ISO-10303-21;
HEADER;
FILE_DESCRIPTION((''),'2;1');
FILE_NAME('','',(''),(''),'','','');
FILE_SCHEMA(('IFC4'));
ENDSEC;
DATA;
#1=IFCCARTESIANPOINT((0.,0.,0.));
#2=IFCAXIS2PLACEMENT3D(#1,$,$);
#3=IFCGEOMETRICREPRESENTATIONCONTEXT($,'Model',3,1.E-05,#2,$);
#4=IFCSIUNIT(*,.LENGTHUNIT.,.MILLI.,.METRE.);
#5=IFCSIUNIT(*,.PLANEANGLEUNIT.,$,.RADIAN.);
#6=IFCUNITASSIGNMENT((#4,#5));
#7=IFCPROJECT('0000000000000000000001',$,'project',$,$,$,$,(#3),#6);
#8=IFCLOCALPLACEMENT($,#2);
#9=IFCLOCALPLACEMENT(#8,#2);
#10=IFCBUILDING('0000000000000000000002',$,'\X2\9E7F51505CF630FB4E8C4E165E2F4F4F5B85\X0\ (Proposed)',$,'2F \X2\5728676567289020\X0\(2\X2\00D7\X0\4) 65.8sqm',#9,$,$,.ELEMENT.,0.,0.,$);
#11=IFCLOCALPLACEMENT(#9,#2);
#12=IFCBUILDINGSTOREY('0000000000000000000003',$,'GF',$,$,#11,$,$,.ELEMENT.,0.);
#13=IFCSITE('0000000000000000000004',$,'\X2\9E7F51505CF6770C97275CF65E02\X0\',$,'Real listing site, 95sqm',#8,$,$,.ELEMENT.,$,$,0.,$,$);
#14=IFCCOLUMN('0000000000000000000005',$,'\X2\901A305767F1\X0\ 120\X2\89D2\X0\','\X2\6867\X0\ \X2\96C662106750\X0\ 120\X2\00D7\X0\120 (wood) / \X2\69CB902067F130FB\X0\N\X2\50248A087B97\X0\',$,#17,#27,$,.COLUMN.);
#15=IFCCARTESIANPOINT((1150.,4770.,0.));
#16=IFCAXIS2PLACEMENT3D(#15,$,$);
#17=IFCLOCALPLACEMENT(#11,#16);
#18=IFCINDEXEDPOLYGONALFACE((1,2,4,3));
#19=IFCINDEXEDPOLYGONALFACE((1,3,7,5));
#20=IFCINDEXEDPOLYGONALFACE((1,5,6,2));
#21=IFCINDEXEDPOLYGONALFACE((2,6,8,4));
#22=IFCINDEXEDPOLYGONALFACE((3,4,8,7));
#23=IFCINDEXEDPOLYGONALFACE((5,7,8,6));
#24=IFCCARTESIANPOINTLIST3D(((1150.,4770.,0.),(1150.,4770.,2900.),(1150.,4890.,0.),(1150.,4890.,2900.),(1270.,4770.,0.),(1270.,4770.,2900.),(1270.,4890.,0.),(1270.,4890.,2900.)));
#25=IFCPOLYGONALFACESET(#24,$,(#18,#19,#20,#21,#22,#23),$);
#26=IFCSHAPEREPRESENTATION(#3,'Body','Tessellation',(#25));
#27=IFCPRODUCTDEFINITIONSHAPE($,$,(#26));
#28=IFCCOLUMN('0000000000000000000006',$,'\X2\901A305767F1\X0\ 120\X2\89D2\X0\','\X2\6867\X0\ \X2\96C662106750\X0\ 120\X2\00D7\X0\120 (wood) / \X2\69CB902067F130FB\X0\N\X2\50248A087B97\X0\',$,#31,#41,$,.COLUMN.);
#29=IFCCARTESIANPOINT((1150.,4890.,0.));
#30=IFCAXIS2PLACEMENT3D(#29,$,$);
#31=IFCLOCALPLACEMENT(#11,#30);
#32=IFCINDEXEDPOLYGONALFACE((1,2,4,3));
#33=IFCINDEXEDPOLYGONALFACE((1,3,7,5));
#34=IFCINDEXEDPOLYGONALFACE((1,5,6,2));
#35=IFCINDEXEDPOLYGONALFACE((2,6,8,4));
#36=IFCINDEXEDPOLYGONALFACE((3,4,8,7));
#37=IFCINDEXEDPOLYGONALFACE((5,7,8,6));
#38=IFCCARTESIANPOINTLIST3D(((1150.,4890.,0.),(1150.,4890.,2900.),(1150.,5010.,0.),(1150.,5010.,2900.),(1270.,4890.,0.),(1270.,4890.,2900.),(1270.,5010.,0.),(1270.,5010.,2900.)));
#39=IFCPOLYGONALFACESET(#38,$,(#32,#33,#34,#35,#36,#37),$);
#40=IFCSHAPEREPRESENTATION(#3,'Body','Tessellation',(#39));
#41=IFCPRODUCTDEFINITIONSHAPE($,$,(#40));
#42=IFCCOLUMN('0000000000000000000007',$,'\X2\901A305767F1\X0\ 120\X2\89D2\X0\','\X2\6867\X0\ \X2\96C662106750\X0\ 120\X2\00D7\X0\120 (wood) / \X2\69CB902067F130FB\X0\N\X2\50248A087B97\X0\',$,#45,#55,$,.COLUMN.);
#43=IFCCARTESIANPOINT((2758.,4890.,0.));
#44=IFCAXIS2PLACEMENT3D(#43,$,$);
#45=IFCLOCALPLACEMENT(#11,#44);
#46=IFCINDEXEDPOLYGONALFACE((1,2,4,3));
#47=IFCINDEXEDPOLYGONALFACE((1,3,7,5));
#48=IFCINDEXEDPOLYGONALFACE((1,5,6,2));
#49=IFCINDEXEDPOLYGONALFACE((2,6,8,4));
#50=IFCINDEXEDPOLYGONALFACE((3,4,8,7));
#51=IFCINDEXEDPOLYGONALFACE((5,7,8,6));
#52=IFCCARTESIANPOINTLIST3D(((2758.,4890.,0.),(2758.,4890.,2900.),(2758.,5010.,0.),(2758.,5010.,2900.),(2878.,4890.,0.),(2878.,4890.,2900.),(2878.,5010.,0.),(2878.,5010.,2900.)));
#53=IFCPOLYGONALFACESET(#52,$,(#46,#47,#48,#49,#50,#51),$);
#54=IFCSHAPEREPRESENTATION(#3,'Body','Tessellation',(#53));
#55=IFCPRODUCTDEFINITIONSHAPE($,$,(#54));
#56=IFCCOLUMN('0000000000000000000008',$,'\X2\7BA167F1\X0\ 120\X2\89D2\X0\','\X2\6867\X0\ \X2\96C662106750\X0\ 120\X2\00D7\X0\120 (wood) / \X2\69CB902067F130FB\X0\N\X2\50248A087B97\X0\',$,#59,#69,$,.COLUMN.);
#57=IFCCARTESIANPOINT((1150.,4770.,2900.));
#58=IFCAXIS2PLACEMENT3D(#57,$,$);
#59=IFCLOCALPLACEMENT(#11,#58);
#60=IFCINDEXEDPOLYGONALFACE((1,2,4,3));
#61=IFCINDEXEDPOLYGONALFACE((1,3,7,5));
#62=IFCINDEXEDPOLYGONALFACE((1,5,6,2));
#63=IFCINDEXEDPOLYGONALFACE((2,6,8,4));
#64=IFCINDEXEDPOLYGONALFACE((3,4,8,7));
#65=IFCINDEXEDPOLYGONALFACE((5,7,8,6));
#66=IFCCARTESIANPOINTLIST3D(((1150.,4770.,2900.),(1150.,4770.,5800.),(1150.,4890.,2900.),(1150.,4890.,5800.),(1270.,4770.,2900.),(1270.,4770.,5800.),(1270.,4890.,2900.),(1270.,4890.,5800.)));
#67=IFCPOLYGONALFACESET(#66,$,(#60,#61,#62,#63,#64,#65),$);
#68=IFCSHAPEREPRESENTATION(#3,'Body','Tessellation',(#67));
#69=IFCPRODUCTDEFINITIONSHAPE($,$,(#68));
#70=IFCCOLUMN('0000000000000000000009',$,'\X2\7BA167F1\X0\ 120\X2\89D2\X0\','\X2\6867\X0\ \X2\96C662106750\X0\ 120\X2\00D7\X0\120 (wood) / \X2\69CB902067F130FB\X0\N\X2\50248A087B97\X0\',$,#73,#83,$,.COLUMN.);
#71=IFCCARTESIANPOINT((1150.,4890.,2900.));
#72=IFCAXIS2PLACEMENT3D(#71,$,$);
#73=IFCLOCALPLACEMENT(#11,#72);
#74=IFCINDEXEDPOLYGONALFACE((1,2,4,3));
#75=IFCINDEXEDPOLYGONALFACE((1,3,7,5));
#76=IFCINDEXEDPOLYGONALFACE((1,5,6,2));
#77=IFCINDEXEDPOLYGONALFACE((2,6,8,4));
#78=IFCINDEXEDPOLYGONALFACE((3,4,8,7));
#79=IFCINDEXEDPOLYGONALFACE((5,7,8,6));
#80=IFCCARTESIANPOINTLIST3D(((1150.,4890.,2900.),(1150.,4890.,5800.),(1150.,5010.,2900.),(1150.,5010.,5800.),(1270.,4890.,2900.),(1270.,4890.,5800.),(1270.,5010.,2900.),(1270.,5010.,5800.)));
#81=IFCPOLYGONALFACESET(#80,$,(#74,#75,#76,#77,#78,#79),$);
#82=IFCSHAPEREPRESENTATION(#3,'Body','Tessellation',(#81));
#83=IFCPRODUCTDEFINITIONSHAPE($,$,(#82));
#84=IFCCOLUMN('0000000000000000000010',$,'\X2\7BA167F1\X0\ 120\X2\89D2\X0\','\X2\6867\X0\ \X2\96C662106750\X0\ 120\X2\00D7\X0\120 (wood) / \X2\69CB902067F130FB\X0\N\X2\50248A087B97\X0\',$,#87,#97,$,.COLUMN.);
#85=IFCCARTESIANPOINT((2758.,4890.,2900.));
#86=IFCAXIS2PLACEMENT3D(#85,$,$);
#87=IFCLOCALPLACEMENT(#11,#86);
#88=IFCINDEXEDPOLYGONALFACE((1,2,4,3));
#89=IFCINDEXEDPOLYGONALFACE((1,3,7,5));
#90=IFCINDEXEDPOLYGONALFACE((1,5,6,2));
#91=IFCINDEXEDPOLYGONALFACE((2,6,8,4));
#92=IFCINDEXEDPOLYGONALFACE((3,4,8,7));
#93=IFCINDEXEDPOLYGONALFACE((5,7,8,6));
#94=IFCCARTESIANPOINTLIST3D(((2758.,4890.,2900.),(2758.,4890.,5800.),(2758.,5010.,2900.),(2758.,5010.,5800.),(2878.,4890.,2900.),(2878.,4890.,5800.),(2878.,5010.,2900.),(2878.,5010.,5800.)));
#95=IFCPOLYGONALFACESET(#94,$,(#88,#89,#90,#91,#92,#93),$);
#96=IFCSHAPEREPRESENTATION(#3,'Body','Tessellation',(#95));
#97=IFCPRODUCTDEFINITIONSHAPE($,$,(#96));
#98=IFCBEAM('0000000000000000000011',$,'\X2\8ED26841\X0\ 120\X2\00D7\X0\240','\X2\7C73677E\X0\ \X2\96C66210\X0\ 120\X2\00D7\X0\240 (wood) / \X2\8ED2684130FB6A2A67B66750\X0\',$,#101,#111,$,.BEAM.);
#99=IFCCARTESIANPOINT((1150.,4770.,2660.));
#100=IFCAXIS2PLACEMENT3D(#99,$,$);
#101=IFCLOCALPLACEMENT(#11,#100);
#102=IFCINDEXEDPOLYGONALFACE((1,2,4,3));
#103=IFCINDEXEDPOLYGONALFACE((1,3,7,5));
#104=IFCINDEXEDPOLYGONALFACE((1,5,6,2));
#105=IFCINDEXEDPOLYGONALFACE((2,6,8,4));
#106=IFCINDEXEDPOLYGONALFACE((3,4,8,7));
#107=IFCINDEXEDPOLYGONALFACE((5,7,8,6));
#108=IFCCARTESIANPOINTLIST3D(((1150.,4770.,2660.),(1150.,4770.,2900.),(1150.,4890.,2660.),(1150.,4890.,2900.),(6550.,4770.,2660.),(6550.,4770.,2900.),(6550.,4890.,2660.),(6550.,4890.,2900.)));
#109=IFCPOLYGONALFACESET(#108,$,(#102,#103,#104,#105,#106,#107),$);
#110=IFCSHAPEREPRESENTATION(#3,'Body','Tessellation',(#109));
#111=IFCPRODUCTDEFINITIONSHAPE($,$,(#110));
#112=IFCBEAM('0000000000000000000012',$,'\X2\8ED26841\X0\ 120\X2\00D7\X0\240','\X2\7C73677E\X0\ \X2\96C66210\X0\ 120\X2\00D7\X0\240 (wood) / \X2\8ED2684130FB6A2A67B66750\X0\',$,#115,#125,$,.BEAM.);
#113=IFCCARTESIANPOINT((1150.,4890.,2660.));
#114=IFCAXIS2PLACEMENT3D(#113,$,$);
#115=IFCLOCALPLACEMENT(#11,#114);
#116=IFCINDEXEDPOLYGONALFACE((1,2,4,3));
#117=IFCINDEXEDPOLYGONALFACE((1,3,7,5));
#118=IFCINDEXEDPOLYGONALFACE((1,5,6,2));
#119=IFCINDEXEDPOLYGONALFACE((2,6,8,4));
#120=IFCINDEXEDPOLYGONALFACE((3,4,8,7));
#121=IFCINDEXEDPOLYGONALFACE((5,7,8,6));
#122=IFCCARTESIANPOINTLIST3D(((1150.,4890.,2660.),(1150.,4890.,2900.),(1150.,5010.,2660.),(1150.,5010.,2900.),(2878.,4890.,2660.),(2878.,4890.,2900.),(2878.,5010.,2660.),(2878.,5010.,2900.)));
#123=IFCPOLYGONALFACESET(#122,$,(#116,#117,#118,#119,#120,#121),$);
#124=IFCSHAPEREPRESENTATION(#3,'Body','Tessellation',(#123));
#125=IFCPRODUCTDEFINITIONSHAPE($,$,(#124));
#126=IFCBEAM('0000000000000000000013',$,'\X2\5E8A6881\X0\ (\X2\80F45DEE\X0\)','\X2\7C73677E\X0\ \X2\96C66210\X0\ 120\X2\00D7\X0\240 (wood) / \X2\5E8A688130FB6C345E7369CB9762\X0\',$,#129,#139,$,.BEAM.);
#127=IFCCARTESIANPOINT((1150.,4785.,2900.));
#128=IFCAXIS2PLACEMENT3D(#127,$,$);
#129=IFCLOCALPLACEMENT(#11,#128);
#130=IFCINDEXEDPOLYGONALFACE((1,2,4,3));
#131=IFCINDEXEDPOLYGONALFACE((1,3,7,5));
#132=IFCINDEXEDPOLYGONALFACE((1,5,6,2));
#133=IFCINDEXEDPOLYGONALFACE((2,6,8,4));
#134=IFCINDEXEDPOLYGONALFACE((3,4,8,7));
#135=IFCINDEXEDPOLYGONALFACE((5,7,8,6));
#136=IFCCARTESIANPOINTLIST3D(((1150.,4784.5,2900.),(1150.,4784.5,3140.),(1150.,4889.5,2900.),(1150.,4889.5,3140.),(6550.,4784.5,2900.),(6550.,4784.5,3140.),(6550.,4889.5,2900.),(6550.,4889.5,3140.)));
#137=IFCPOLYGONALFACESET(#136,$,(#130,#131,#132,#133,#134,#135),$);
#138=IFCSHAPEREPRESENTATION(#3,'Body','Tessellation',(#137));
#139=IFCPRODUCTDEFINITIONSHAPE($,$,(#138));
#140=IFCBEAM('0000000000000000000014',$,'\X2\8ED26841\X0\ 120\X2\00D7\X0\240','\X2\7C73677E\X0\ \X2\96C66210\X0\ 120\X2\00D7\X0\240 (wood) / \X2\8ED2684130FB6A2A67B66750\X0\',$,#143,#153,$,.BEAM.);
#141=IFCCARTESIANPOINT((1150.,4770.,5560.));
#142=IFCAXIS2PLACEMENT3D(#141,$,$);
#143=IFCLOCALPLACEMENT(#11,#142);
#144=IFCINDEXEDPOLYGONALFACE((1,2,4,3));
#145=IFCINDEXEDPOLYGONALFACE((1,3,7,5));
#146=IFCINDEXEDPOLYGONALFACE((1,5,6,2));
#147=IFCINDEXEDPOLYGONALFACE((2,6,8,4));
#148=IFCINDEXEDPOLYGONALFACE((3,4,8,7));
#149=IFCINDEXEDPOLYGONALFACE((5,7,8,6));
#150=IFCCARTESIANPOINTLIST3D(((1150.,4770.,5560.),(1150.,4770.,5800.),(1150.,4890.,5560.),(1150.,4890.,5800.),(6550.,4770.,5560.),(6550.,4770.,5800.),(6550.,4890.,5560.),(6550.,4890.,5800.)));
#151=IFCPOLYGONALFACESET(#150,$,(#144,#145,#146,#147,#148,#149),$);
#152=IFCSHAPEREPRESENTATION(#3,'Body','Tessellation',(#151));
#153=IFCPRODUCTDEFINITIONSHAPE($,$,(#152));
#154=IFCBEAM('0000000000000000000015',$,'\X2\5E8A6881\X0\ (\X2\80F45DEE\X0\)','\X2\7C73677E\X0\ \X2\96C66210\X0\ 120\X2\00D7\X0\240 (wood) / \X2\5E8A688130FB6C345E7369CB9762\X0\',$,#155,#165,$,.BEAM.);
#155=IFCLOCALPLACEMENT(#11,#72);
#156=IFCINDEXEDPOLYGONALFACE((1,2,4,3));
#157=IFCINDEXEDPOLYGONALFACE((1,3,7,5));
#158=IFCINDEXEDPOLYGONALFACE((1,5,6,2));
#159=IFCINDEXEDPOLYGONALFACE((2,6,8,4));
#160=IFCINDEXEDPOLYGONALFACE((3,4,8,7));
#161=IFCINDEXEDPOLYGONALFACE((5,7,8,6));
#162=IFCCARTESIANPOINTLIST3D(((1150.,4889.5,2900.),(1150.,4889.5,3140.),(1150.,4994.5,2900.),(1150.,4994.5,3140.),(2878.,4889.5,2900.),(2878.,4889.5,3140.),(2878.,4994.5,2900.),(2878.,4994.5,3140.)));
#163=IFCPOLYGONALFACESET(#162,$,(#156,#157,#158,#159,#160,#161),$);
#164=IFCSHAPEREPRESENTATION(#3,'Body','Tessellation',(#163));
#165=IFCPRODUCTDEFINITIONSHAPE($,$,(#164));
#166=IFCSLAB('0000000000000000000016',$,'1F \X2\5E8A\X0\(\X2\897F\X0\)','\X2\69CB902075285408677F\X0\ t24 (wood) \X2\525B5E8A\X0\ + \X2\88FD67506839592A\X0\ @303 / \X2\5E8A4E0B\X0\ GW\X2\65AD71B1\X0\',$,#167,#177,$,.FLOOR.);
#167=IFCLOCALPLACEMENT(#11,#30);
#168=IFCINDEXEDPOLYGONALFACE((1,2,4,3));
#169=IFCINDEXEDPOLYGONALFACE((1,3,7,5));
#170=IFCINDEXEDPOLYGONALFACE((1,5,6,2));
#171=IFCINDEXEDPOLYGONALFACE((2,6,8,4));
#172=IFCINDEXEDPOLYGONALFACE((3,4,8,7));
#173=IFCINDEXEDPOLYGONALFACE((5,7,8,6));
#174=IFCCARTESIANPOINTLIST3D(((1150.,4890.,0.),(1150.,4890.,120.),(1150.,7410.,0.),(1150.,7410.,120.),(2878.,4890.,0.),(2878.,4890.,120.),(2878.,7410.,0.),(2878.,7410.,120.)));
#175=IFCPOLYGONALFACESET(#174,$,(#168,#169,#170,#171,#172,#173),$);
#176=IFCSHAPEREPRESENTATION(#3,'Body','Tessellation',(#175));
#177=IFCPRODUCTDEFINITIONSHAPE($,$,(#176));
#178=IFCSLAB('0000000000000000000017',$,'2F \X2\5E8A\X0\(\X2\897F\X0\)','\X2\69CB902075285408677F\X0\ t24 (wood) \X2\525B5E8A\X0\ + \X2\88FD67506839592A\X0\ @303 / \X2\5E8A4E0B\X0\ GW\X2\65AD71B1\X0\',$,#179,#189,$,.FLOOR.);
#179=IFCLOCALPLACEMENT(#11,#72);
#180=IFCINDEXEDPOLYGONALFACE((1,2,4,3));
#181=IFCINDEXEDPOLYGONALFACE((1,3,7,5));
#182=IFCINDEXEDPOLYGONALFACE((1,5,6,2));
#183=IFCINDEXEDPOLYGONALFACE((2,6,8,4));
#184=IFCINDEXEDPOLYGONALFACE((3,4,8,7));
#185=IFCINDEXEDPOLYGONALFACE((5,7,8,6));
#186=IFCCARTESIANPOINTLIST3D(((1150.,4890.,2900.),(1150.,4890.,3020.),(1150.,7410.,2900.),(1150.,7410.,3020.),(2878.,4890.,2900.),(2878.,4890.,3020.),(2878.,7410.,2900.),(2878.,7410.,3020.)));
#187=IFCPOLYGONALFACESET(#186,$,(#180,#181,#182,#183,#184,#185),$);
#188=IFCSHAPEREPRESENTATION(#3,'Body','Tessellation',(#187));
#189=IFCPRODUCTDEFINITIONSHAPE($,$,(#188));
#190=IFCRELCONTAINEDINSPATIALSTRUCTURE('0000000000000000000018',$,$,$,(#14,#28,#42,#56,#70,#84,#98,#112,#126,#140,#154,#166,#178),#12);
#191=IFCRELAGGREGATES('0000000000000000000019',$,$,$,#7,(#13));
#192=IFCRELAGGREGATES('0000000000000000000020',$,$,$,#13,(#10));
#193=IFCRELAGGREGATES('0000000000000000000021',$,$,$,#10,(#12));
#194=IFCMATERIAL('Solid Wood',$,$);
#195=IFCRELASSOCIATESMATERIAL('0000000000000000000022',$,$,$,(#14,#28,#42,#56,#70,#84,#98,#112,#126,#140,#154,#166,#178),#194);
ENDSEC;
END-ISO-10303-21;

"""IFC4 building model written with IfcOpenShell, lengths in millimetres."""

from ifc_helpers import new_model, si_unit, frame, frame_2d, origin, place, context, project, spatial, rectangle, extrude, material, element, save


model = new_model("IFC4")

# Units and contexts
model_context = context("Model", 3, precision=1e-05, world=origin())
ifc_project = project(units=[si_unit("LENGTHUNIT", "METRE", prefix="MILLI"), si_unit("PLANEANGLEUNIT", "RADIAN")], contexts=[model_context])

# Site, building, storey
site_placement = place(None, origin())
site = spatial("IfcSite", under=ifc_project, at=site_placement, Name="鹿児島県霧島市", ObjectType="Real listing site, 95sqm", CompositionType="ELEMENT", RefElevation=0.0)
building_placement = place(site_placement, origin())
building = spatial("IfcBuilding", under=site, at=building_placement, Name="鹿児島・二世帯住宅 (Proposed)", ObjectType="2F 在来木造(2×4) 65.8sqm", CompositionType="ELEMENT", ElevationOfRefHeight=0.0, ElevationOfTerrain=0.0)
storey_placement = place(building_placement, origin())
storey = spatial("IfcBuildingStorey", under=building, at=storey_placement, Name="GF", CompositionType="ELEMENT", Elevation=0.0)

# Columns
ifc_material_1 = material(Name="Solid Wood")
column_1_placement = place(storey_placement, frame((1150.0, 4770.0, 0.0)))
element("IfcColumn", 1, at=column_1_placement, inside=storey, material=ifc_material_1, Name="通し柱 120角", Description="桧 集成材 120×120 (wood) / 構造柱・N値計算", PredefinedType="COLUMN", context=model_context, shape_type="SweptSolid", body=[
    extrude(rectangle(XDim=120.0, YDim=120.0, at=frame_2d((60.0, 60.0))), frame((1150.0, 4770.0, 0.0)), (0.0, 0.0, 1.0), 2900.0),
])
column_2_placement = place(storey_placement, frame((1150.0, 4890.0, 0.0)))
element("IfcColumn", 2, at=column_2_placement, inside=storey, material=ifc_material_1, Name="通し柱 120角", Description="桧 集成材 120×120 (wood) / 構造柱・N値計算", PredefinedType="COLUMN", context=model_context, shape_type="SweptSolid", body=[
    extrude(rectangle(XDim=120.0, YDim=120.0, at=frame_2d((60.0, 60.0))), frame((1150.0, 4890.0, 0.0)), (0.0, 0.0, 1.0), 2900.0),
])
column_3_placement = place(storey_placement, frame((2758.0, 4890.0, 0.0)))
element("IfcColumn", 3, at=column_3_placement, inside=storey, material=ifc_material_1, Name="通し柱 120角", Description="桧 集成材 120×120 (wood) / 構造柱・N値計算", PredefinedType="COLUMN", context=model_context, shape_type="SweptSolid", body=[
    extrude(rectangle(XDim=120.0, YDim=120.0, at=frame_2d((60.0, 60.0))), frame((2758.0, 4890.0, 0.0)), (0.0, 0.0, 1.0), 2900.0),
])
column_4_placement = place(storey_placement, frame((1150.0, 4770.0, 2900.0)))
element("IfcColumn", 4, at=column_4_placement, inside=storey, material=ifc_material_1, Name="管柱 120角", Description="桧 集成材 120×120 (wood) / 構造柱・N値計算", PredefinedType="COLUMN", context=model_context, shape_type="SweptSolid", body=[
    extrude(rectangle(XDim=120.0, YDim=120.0, at=frame_2d((60.0, 60.0))), frame((1150.0, 4770.0, 2900.0)), (0.0, 0.0, 1.0), 2900.0),
])
column_5_placement = place(storey_placement, frame((1150.0, 4890.0, 2900.0)))
element("IfcColumn", 5, at=column_5_placement, inside=storey, material=ifc_material_1, Name="管柱 120角", Description="桧 集成材 120×120 (wood) / 構造柱・N値計算", PredefinedType="COLUMN", context=model_context, shape_type="SweptSolid", body=[
    extrude(rectangle(XDim=120.0, YDim=120.0, at=frame_2d((60.0, 60.0))), frame((1150.0, 4890.0, 2900.0)), (0.0, 0.0, 1.0), 2900.0),
])
column_6_placement = place(storey_placement, frame((2758.0, 4890.0, 2900.0)))
element("IfcColumn", 6, at=column_6_placement, inside=storey, material=ifc_material_1, Name="管柱 120角", Description="桧 集成材 120×120 (wood) / 構造柱・N値計算", PredefinedType="COLUMN", context=model_context, shape_type="SweptSolid", body=[
    extrude(rectangle(XDim=120.0, YDim=120.0, at=frame_2d((60.0, 60.0))), frame((2758.0, 4890.0, 2900.0)), (0.0, 0.0, 1.0), 2900.0),
])

# Beams
beam_1_placement = place(storey_placement, frame((1150.0, 4770.0, 2660.0)))
element("IfcBeam", 7, at=beam_1_placement, inside=storey, material=ifc_material_1, Name="軒桁 120×240", Description="米松 集成 120×240 (wood) / 軒桁・横架材", PredefinedType="BEAM", context=model_context, shape_type="SweptSolid", body=[
    extrude(rectangle(XDim=5400.0, YDim=120.0, at=frame_2d((2700.0, 60.0))), frame((1150.0, 4770.0, 2660.0)), (0.0, 0.0, 1.0), 240.0),
])
beam_2_placement = place(storey_placement, frame((1150.0, 4890.0, 2660.0)))
element("IfcBeam", 8, at=beam_2_placement, inside=storey, material=ifc_material_1, Name="軒桁 120×240", Description="米松 集成 120×240 (wood) / 軒桁・横架材", PredefinedType="BEAM", context=model_context, shape_type="SweptSolid", body=[
    extrude(rectangle(XDim=1728.0, YDim=120.0, at=frame_2d((864.0, 60.0))), frame((1150.0, 4890.0, 2660.0)), (0.0, 0.0, 1.0), 240.0),
])
beam_3_placement = place(storey_placement, frame((1150.0, 4785.0, 2900.0)))
element("IfcBeam", 9, at=beam_3_placement, inside=storey, material=ifc_material_1, Name="床梁 (胴差)", Description="米松 集成 120×240 (wood) / 床梁・水平構面", PredefinedType="BEAM", context=model_context, shape_type="SweptSolid", body=[
    extrude(rectangle(XDim=5400.0, YDim=105.0, at=frame_2d((2700.0, 52.0))), frame((1150.0, 4785.0, 2900.0)), (0.0, 0.0, 1.0), 240.0),
])
beam_4_placement = place(storey_placement, frame((1150.0, 4770.0, 5560.0)))
element("IfcBeam", 10, at=beam_4_placement, inside=storey, material=ifc_material_1, Name="軒桁 120×240", Description="米松 集成 120×240 (wood) / 軒桁・横架材", PredefinedType="BEAM", context=model_context, shape_type="SweptSolid", body=[
    extrude(rectangle(XDim=5400.0, YDim=120.0, at=frame_2d((2700.0, 60.0))), frame((1150.0, 4770.0, 5560.0)), (0.0, 0.0, 1.0), 240.0),
])
beam_5_placement = place(storey_placement, frame((1150.0, 4890.0, 2900.0)))
element("IfcBeam", 11, at=beam_5_placement, inside=storey, material=ifc_material_1, Name="床梁 (胴差)", Description="米松 集成 120×240 (wood) / 床梁・水平構面", PredefinedType="BEAM", context=model_context, shape_type="SweptSolid", body=[
    extrude(rectangle(XDim=1728.0, YDim=105.0, at=frame_2d((864.0, 52.0))), frame((1150.0, 4890.0, 2900.0)), (0.0, 0.0, 1.0), 240.0),
])

# Slabs
slab_1_placement = place(storey_placement, frame((1150.0, 4890.0, 0.0)))
element("IfcSlab", 12, at=slab_1_placement, inside=storey, material=ifc_material_1, Name="1F 床(西)", Description="構造用合板 t24 (wood) 剛床 + 製材根太 @303 / 床下 GW断熱", PredefinedType="FLOOR", context=model_context, shape_type="SweptSolid", body=[
    extrude(rectangle(XDim=1728.0, YDim=2520.0, at=frame_2d((864.0, 1260.0))), frame((1150.0, 4890.0, 0.0)), (0.0, 0.0, 1.0), 120.0),
])
slab_2_placement = place(storey_placement, frame((1150.0, 4890.0, 2900.0)))
element("IfcSlab", 13, at=slab_2_placement, inside=storey, material=ifc_material_1, Name="2F 床(西)", Description="構造用合板 t24 (wood) 剛床 + 製材根太 @303 / 床下 GW断熱", PredefinedType="FLOOR", context=model_context, shape_type="SweptSolid", body=[
    extrude(rectangle(XDim=1728.0, YDim=2520.0, at=frame_2d((864.0, 1260.0))), frame((1150.0, 4890.0, 2900.0)), (0.0, 0.0, 1.0), 120.0),
])

save(model, "model.ifc")
